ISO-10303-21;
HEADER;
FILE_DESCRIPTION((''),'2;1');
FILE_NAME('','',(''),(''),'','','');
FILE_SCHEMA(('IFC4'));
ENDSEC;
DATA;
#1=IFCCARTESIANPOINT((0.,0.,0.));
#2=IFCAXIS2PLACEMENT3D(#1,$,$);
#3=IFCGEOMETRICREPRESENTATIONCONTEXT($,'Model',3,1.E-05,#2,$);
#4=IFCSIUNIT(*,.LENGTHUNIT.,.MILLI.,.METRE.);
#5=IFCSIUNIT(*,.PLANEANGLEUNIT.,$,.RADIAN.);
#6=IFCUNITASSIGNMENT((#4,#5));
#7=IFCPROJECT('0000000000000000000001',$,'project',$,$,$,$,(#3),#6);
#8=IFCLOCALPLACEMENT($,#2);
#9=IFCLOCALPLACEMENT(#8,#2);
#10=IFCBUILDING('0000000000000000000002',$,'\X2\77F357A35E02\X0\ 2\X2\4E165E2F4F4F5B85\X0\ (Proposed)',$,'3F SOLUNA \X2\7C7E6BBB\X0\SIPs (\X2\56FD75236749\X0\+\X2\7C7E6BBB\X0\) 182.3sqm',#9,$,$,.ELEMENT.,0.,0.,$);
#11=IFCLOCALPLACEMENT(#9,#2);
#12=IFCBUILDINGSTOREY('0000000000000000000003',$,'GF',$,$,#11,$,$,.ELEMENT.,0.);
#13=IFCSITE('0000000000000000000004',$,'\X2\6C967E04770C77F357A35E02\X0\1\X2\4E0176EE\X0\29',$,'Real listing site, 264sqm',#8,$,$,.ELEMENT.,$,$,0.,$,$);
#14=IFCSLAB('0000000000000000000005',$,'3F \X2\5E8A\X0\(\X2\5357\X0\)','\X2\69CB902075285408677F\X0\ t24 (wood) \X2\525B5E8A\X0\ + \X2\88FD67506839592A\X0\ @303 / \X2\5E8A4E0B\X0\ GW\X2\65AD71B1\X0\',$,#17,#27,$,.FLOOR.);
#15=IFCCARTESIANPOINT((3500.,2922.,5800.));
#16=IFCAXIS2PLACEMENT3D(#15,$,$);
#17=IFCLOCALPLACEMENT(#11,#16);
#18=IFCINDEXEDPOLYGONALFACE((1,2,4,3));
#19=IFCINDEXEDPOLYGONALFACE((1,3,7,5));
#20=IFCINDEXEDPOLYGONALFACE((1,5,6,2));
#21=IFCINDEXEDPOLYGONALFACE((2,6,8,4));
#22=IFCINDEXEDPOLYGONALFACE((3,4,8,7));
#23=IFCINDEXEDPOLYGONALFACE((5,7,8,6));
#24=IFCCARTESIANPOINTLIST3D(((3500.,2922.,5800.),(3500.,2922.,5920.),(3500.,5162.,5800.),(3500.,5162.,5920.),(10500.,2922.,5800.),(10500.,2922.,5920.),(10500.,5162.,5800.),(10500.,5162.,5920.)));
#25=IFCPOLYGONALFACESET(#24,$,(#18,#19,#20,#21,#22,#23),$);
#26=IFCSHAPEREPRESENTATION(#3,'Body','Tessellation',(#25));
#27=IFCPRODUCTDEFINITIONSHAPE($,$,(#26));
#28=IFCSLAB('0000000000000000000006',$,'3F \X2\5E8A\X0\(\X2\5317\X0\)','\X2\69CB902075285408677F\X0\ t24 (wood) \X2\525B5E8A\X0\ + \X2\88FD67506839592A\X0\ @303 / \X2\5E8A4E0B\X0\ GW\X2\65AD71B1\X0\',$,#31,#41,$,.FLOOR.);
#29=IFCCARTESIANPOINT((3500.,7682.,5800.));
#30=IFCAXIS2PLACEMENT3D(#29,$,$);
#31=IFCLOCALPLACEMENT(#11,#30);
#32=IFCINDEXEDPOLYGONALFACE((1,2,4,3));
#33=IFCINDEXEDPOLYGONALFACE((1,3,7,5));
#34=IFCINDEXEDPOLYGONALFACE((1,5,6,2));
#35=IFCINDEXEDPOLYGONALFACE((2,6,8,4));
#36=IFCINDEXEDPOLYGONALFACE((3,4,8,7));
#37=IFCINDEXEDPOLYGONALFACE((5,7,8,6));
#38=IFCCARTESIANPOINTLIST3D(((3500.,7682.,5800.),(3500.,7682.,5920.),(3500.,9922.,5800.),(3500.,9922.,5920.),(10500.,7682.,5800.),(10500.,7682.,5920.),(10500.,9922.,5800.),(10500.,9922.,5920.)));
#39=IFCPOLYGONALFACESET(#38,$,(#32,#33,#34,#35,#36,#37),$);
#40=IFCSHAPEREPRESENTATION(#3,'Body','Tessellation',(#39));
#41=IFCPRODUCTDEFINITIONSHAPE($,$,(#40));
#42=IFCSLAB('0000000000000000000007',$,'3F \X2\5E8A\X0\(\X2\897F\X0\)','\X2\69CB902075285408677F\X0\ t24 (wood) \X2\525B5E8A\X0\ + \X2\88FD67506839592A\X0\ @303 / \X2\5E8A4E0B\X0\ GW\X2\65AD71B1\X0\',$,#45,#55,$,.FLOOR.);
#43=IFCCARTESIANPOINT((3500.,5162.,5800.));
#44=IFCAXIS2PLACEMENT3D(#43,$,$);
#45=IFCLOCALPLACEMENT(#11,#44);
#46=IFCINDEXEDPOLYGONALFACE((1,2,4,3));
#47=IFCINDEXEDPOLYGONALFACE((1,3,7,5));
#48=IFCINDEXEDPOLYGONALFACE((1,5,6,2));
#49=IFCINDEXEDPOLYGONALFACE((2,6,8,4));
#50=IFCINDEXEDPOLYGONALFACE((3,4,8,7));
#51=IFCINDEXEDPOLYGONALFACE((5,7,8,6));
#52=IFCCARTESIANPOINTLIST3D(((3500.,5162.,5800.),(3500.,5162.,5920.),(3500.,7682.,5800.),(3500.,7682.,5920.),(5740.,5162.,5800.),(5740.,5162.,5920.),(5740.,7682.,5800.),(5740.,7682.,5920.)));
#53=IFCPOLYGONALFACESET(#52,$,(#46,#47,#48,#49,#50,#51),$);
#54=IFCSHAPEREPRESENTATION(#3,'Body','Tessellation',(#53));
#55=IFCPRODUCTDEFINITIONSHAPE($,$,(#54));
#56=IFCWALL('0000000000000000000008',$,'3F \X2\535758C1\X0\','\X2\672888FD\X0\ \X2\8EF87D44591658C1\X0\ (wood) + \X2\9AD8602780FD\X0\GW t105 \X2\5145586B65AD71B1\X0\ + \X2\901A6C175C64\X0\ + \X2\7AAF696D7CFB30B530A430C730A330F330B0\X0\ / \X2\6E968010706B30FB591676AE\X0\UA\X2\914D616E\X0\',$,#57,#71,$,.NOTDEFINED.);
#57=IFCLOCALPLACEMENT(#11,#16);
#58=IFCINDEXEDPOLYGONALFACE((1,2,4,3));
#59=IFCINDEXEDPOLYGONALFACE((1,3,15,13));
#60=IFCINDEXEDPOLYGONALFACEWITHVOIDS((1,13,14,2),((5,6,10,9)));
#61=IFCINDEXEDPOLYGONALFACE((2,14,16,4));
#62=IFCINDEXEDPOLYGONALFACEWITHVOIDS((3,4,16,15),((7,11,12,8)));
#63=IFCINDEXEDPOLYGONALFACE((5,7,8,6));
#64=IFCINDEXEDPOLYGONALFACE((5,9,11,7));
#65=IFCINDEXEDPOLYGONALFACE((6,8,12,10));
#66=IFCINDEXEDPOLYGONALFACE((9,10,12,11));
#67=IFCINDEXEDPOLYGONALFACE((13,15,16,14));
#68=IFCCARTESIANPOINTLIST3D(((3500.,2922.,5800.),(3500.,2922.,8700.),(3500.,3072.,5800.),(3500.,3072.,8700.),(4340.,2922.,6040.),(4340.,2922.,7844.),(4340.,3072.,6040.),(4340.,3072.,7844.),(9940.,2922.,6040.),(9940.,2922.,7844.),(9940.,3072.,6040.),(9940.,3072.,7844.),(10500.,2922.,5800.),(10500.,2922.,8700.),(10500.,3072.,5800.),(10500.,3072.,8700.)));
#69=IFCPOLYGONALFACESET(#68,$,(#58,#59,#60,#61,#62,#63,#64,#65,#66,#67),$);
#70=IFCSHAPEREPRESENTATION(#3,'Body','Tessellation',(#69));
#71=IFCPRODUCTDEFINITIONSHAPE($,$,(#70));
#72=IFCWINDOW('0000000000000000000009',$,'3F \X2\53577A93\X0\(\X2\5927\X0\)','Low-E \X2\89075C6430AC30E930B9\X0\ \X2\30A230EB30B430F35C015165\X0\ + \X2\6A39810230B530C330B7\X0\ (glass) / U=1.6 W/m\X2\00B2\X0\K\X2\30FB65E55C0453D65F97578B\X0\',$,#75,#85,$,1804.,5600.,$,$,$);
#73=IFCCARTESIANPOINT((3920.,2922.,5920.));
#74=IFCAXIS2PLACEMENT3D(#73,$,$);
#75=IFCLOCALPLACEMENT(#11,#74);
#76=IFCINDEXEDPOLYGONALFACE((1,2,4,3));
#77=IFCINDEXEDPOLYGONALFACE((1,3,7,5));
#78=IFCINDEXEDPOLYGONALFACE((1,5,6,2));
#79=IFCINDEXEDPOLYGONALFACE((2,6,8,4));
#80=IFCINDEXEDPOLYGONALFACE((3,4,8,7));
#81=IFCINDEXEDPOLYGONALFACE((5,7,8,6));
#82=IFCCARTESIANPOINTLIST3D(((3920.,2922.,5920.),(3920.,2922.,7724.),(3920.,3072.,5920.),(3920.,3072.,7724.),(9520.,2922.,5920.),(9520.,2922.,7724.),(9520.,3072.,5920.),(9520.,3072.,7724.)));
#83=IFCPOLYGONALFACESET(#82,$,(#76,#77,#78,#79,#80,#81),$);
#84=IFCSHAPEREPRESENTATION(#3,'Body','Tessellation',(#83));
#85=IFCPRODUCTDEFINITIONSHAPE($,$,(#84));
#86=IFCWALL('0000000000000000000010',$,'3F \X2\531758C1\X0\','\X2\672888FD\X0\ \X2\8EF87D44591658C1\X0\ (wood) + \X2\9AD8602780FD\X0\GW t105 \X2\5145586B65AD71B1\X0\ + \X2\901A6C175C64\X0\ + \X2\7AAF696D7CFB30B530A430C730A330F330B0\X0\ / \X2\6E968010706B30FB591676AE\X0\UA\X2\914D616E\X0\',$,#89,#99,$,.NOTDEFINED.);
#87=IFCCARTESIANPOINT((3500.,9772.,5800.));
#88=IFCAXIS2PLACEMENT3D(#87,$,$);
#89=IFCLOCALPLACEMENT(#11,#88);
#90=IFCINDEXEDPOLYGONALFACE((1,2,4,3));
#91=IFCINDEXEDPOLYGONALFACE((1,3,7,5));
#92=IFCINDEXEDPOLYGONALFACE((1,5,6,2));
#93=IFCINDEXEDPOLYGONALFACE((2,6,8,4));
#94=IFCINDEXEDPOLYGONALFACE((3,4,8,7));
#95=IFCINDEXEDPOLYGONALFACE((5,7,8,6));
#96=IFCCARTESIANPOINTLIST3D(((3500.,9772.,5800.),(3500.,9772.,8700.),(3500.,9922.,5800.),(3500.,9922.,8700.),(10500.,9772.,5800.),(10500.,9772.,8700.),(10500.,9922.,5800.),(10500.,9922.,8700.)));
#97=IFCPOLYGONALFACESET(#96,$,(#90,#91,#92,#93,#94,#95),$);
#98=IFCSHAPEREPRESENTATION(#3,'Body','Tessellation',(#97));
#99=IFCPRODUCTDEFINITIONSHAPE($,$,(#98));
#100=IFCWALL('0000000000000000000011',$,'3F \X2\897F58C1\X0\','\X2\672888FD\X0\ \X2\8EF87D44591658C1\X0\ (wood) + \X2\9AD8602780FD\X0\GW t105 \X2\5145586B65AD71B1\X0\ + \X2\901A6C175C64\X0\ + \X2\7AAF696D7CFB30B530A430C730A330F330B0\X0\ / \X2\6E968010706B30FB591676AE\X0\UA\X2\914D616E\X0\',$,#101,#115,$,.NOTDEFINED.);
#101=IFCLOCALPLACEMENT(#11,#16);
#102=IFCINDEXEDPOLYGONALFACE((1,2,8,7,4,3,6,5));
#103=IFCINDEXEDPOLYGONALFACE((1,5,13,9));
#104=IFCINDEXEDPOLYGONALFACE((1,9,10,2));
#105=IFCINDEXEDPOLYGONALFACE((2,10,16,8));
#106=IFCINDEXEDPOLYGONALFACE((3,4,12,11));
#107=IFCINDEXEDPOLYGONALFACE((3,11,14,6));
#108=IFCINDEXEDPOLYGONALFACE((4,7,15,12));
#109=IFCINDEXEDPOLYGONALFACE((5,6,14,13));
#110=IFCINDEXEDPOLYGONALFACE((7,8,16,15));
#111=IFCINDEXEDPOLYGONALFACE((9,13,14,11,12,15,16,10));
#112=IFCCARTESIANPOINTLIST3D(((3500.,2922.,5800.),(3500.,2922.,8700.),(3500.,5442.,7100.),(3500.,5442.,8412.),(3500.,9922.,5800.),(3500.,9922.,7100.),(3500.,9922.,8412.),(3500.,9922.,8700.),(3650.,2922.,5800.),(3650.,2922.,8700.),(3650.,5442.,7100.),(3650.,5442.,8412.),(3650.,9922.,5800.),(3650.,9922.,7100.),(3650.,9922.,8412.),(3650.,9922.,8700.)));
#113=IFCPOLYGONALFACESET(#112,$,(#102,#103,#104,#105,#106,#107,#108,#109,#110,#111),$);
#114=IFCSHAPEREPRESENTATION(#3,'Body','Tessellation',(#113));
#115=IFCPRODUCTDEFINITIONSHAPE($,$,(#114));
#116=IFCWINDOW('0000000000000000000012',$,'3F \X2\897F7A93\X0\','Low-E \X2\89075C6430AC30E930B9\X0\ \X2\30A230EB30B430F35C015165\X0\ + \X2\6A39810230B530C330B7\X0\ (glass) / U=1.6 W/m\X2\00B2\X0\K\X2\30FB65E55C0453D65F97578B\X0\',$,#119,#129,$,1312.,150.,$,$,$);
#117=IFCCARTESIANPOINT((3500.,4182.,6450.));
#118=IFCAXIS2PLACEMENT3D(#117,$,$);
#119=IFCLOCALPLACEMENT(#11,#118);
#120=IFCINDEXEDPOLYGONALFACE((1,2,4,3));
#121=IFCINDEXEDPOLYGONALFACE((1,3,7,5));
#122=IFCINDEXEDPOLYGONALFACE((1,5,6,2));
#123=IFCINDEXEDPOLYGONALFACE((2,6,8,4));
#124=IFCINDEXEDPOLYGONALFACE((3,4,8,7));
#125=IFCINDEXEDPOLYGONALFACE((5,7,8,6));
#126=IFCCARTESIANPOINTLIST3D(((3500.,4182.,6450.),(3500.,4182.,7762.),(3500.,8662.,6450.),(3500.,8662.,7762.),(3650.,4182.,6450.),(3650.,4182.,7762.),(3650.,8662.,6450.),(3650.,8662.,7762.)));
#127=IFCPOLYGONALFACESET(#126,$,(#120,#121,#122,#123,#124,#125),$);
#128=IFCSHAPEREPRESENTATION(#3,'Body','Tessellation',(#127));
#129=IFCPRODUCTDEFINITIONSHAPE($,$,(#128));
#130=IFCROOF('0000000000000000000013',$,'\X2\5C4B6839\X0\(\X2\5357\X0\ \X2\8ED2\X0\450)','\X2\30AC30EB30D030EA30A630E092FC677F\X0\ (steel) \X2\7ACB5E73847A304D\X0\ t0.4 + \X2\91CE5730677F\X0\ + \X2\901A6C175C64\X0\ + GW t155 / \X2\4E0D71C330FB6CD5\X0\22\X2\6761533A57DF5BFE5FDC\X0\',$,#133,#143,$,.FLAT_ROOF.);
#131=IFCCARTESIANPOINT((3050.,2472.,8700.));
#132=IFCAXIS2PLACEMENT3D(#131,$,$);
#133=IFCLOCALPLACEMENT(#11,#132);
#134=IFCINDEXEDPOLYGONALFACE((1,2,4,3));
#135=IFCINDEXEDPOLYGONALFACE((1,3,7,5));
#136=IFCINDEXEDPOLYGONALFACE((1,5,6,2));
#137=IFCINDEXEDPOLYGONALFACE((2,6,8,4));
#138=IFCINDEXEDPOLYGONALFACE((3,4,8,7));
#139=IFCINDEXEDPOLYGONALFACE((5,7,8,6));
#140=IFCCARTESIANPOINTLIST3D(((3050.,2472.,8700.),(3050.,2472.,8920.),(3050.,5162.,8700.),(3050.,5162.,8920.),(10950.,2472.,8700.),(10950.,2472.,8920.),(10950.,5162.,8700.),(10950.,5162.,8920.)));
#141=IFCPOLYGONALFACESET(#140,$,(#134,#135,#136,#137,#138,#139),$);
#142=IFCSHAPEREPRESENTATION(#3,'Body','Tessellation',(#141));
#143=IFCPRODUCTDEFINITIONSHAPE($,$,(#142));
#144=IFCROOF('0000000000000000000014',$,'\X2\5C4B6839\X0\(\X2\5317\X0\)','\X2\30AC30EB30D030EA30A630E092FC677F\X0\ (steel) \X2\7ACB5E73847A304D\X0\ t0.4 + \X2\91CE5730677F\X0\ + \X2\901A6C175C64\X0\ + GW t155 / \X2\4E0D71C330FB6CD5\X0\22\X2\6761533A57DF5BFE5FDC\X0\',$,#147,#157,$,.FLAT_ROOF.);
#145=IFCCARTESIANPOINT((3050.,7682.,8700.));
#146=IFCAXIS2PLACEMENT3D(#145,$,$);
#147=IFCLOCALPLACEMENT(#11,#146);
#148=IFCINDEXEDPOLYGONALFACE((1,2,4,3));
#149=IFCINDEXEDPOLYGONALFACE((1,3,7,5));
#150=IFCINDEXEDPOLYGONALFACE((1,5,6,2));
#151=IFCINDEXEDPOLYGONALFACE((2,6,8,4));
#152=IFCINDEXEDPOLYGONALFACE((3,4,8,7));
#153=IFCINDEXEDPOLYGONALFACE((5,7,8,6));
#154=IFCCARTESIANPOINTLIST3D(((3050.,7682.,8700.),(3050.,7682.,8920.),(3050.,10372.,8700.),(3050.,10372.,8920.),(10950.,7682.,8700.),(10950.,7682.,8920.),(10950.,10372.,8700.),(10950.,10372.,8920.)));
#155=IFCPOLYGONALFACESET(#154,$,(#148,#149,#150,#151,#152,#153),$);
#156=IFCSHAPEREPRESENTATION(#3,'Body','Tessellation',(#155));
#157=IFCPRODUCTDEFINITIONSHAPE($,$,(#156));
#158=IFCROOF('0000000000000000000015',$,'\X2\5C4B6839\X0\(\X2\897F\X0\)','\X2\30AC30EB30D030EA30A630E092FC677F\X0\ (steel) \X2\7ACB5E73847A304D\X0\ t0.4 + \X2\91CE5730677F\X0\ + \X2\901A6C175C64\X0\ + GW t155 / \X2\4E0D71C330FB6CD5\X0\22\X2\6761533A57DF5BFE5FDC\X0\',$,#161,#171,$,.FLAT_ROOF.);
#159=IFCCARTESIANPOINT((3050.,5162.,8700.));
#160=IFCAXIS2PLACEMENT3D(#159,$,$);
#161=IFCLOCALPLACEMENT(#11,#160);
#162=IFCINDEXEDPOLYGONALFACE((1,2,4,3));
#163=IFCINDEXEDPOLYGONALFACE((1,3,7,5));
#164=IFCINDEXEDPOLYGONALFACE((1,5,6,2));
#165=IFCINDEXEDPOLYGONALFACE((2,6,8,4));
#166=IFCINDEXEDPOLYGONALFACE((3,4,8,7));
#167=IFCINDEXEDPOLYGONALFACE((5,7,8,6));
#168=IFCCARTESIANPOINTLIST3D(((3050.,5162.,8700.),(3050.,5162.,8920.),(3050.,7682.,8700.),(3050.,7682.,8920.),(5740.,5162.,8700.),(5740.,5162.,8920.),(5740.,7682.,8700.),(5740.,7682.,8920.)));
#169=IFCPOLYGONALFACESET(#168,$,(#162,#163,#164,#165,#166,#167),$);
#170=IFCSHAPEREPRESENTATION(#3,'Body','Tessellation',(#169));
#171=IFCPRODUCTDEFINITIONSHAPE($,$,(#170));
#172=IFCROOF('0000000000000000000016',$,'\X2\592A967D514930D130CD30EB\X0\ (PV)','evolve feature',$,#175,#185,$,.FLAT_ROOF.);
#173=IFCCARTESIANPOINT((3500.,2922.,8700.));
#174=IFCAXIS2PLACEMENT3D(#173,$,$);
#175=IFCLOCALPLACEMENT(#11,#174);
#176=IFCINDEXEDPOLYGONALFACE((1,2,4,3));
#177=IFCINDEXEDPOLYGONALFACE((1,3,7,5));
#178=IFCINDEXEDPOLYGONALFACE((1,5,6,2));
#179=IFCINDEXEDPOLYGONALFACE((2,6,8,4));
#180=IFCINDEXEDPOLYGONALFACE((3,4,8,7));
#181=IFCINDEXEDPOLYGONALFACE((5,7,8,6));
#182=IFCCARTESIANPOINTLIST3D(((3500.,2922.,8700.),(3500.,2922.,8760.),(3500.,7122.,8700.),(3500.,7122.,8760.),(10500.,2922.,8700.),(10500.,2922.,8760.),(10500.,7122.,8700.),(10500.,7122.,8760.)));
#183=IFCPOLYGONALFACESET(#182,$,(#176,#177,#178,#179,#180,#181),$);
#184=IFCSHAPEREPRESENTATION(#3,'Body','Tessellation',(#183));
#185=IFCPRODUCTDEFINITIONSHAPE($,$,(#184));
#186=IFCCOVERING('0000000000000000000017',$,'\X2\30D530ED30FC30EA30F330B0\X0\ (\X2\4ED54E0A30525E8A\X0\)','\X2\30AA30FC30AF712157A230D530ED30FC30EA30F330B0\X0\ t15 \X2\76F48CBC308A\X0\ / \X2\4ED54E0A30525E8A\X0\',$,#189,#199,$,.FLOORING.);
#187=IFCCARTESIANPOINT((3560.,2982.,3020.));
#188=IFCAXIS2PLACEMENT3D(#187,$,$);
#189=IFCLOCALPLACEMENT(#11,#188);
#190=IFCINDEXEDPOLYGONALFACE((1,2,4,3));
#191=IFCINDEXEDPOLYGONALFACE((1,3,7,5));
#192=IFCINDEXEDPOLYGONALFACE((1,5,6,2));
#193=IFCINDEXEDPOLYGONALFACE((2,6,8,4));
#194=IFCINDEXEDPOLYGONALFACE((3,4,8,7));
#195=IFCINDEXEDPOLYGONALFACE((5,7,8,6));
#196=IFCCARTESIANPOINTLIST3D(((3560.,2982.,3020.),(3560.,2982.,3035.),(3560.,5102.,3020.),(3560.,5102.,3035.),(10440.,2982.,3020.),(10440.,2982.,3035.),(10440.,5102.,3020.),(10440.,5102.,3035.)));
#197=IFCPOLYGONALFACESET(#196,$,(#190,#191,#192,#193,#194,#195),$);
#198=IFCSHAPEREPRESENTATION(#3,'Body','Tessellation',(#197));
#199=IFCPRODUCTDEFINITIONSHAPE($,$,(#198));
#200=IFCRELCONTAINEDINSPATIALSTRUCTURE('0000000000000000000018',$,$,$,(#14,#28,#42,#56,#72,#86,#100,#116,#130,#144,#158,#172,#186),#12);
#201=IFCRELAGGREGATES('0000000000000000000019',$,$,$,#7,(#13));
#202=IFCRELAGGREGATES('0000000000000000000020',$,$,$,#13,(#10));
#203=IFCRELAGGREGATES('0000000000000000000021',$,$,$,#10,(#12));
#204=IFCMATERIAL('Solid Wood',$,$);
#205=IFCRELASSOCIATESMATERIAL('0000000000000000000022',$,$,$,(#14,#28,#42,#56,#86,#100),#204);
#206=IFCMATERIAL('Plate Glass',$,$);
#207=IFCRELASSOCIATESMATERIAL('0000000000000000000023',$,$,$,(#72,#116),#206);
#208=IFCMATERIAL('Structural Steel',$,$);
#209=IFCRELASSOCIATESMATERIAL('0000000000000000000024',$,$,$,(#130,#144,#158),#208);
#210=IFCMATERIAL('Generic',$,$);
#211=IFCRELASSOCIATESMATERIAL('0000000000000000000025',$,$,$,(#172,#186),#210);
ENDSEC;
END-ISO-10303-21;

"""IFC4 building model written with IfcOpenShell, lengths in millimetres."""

from ifc_helpers import new_model, si_unit, frame, frame_2d, origin, place, context, project, spatial, rectangle, extrude, material, element, fill, save


model = new_model("IFC4")

# Units and contexts
model_context = context("Model", 3, precision=1e-05, world=origin())
ifc_project = project(units=[si_unit("LENGTHUNIT", "METRE", prefix="MILLI"), si_unit("PLANEANGLEUNIT", "RADIAN")], contexts=[model_context])

# Site, building, storey
site_placement = place(None, origin())
site = spatial("IfcSite", under=ifc_project, at=site_placement, Name="沖縄県石垣市1丁目29", ObjectType="Real listing site, 264sqm", CompositionType="ELEMENT", RefElevation=0.0)
building_placement = place(site_placement, origin())
building = spatial("IfcBuilding", under=site, at=building_placement, Name="石垣市 2世帯住宅 (Proposed)", ObjectType="3F SOLUNA 籾殻SIPs (国産杉+籾殻) 182.3sqm", CompositionType="ELEMENT", ElevationOfRefHeight=0.0, ElevationOfTerrain=0.0)
storey_placement = place(building_placement, origin())
storey = spatial("IfcBuildingStorey", under=building, at=storey_placement, Name="GF", CompositionType="ELEMENT", Elevation=0.0)

# Slabs
ifc_material_1 = material(Name="Solid Wood")
slab_1_placement = place(storey_placement, frame((3500.0, 2922.0, 5800.0)))
element("IfcSlab", 1, at=slab_1_placement, inside=storey, material=ifc_material_1, Name="3F 床(南)", Description="構造用合板 t24 (wood) 剛床 + 製材根太 @303 / 床下 GW断熱", PredefinedType="FLOOR", context=model_context, shape_type="SweptSolid", body=[
    extrude(rectangle(XDim=7000.0, YDim=2240.0, at=frame_2d((3500.0, 1120.0))), frame((3500.0, 2922.0, 5800.0)), (0.0, 0.0, 1.0), 120.0),
])
slab_2_placement = place(storey_placement, frame((3500.0, 7682.0, 5800.0)))
element("IfcSlab", 2, at=slab_2_placement, inside=storey, material=ifc_material_1, Name="3F 床(北)", Description="構造用合板 t24 (wood) 剛床 + 製材根太 @303 / 床下 GW断熱", PredefinedType="FLOOR", context=model_context, shape_type="SweptSolid", body=[
    extrude(rectangle(XDim=7000.0, YDim=2240.0, at=frame_2d((3500.0, 1120.0))), frame((3500.0, 7682.0, 5800.0)), (0.0, 0.0, 1.0), 120.0),
])
slab_3_placement = place(storey_placement, frame((3500.0, 5162.0, 5800.0)))
element("IfcSlab", 3, at=slab_3_placement, inside=storey, material=ifc_material_1, Name="3F 床(西)", Description="構造用合板 t24 (wood) 剛床 + 製材根太 @303 / 床下 GW断熱", PredefinedType="FLOOR", context=model_context, shape_type="SweptSolid", body=[
    extrude(rectangle(XDim=2240.0, YDim=2520.0, at=frame_2d((1120.0, 1260.0))), frame((3500.0, 5162.0, 5800.0)), (0.0, 0.0, 1.0), 120.0),
])

# Wall, opening, window
wall_1_placement = place(storey_placement, frame((3500.0, 2922.0, 5800.0)))
wall_1 = element("IfcWall", 4, at=wall_1_placement, inside=storey, material=ifc_material_1, Name="3F 南壁", Description="木製 軸組外壁 (wood) + 高性能GW t105 充填断熱 + 通気層 + 窯業系サイディング / 準耐火・外皮UA配慮", PredefinedType="NOTDEFINED", context=model_context, shape_type="SweptSolid", body=[
    extrude(rectangle(XDim=7000.0, YDim=150.0, at=frame_2d((3500.0, 75.0))), frame((3500.0, 2922.0, 5800.0)), (0.0, 0.0, 1.0), 2900.0),
])
opening_1_placement = place(storey_placement, frame((3920.0, 2922.0, 5920.0)))
opening_1 = element("IfcOpeningElement", 5, at=opening_1_placement, cuts=wall_1, PredefinedType="NOTDEFINED", context=model_context, shape_type="SweptSolid", body=[
    extrude(rectangle(XDim=5600.0, YDim=150.0, at=frame_2d((2800.0, 75.0))), frame((3920.0, 2922.0, 5920.0)), (0.0, 0.0, 1.0), 1804.0),
])
ifc_material_2 = material(Name="Plate Glass")
window_1_placement = place(storey_placement, frame((3920.0, 2922.0, 5920.0)))
window_1 = element("IfcWindow", 6, at=window_1_placement, inside=storey, material=ifc_material_2, Name="3F 南窓(大)", Description="Low-E 複層ガラス アルゴン封入 + 樹脂サッシ (glass) / U=1.6 W/m²K・日射取得型", OverallHeight=1804.0, OverallWidth=5600.0, context=model_context, shape_type="SweptSolid", body=[
    extrude(rectangle(XDim=5600.0, YDim=150.0, at=frame_2d((2800.0, 75.0))), frame((3920.0, 2922.0, 5920.0)), (0.0, 0.0, 1.0), 1804.0),
])
fill(opening_1, window_1)

# Wall
wall_2_placement = place(storey_placement, frame((3500.0, 9772.0, 5800.0)))
element("IfcWall", 7, at=wall_2_placement, inside=storey, material=ifc_material_1, Name="3F 北壁", Description="木製 軸組外壁 (wood) + 高性能GW t105 充填断熱 + 通気層 + 窯業系サイディング / 準耐火・外皮UA配慮", PredefinedType="NOTDEFINED", context=model_context, shape_type="SweptSolid", body=[
    extrude(rectangle(XDim=7000.0, YDim=150.0, at=frame_2d((3500.0, 75.0))), frame((3500.0, 9772.0, 5800.0)), (0.0, 0.0, 1.0), 2900.0),
])

# Wall, opening, window
wall_3_placement = place(storey_placement, frame((3500.0, 2922.0, 5800.0)))
wall_3 = element("IfcWall", 8, at=wall_3_placement, inside=storey, material=ifc_material_1, Name="3F 西壁", Description="木製 軸組外壁 (wood) + 高性能GW t105 充填断熱 + 通気層 + 窯業系サイディング / 準耐火・外皮UA配慮", PredefinedType="NOTDEFINED", context=model_context, shape_type="SweptSolid", body=[
    extrude(rectangle(XDim=150.0, YDim=7000.0, at=frame_2d((75.0, 3500.0))), frame((3500.0, 2922.0, 5800.0)), (0.0, 0.0, 1.0), 2900.0),
])
opening_2_placement = place(storey_placement, frame((3500.0, 4182.0, 6450.0)))
opening_2 = element("IfcOpeningElement", 9, at=opening_2_placement, cuts=wall_3, PredefinedType="NOTDEFINED", context=model_context, shape_type="SweptSolid", body=[
    extrude(rectangle(XDim=150.0, YDim=4480.0, at=frame_2d((75.0, 2240.0))), frame((3500.0, 4182.0, 6450.0)), (0.0, 0.0, 1.0), 1312.0),
])
window_2_placement = place(storey_placement, frame((3500.0, 4182.0, 6450.0)))
window_2 = element("IfcWindow", 10, at=window_2_placement, inside=storey, material=ifc_material_2, Name="3F 西窓", Description="Low-E 複層ガラス アルゴン封入 + 樹脂サッシ (glass) / U=1.6 W/m²K・日射取得型", OverallHeight=1312.0, OverallWidth=150.0, context=model_context, shape_type="SweptSolid", body=[
    extrude(rectangle(XDim=150.0, YDim=4480.0, at=frame_2d((75.0, 2240.0))), frame((3500.0, 4182.0, 6450.0)), (0.0, 0.0, 1.0), 1312.0),
])
fill(opening_2, window_2)

# Roofs
ifc_material_3 = material(Name="Structural Steel")
roof_1_placement = place(storey_placement, frame((3050.0, 2472.0, 8700.0)))
element("IfcRoof", 11, at=roof_1_placement, inside=storey, material=ifc_material_3, Name="屋根(南 軒450)", Description="ガルバリウム鋼板 (steel) 立平葺き t0.4 + 野地板 + 通気層 + GW t155 / 不燃・法22条区域対応", PredefinedType="FLAT_ROOF", context=model_context, shape_type="SweptSolid", body=[
    extrude(rectangle(XDim=7900.0, YDim=2690.0, at=frame_2d((3950.0, 1345.0))), frame((3050.0, 2472.0, 8700.0)), (0.0, 0.0, 1.0), 220.0),
])
roof_2_placement = place(storey_placement, frame((3050.0, 7682.0, 8700.0)))
element("IfcRoof", 12, at=roof_2_placement, inside=storey, material=ifc_material_3, Name="屋根(北)", Description="ガルバリウム鋼板 (steel) 立平葺き t0.4 + 野地板 + 通気層 + GW t155 / 不燃・法22条区域対応", PredefinedType="FLAT_ROOF", context=model_context, shape_type="SweptSolid", body=[
    extrude(rectangle(XDim=7900.0, YDim=2690.0, at=frame_2d((3950.0, 1345.0))), frame((3050.0, 7682.0, 8700.0)), (0.0, 0.0, 1.0), 220.0),
])
roof_3_placement = place(storey_placement, frame((3050.0, 5162.0, 8700.0)))
element("IfcRoof", 13, at=roof_3_placement, inside=storey, material=ifc_material_3, Name="屋根(西)", Description="ガルバリウム鋼板 (steel) 立平葺き t0.4 + 野地板 + 通気層 + GW t155 / 不燃・法22条区域対応", PredefinedType="FLAT_ROOF", context=model_context, shape_type="SweptSolid", body=[
    extrude(rectangle(XDim=2690.0, YDim=2520.0, at=frame_2d((1345.0, 1260.0))), frame((3050.0, 5162.0, 8700.0)), (0.0, 0.0, 1.0), 220.0),
])
ifc_material_4 = material(Name="Generic")
roof_4_placement = place(storey_placement, frame((3500.0, 2922.0, 8700.0)))
element("IfcRoof", 14, at=roof_4_placement, inside=storey, material=ifc_material_4, Name="太陽光パネル (PV)", Description="evolve feature", PredefinedType="FLAT_ROOF", context=model_context, shape_type="SweptSolid", body=[
    extrude(rectangle(XDim=7000.0, YDim=4200.0, at=frame_2d((3500.0, 2100.0))), frame((3500.0, 2922.0, 8700.0)), (0.0, 0.0, 1.0), 60.0),
])

# Covering
covering_1_placement = place(storey_placement, frame((3560.0, 2982.0, 3020.0)))
element("IfcCovering", 15, at=covering_1_placement, inside=storey, material=ifc_material_4, Name="フローリング (仕上げ床)", Description="オーク無垢フローリング t15 直貼り / 仕上げ床", PredefinedType="FLOORING", context=model_context, shape_type="SweptSolid", body=[
    extrude(rectangle(XDim=6880.0, YDim=2120.0, at=frame_2d((3440.0, 1060.0))), frame((3560.0, 2982.0, 3020.0)), (0.0, 0.0, 1.0), 15.0),
])

save(model, "model.ifc")
